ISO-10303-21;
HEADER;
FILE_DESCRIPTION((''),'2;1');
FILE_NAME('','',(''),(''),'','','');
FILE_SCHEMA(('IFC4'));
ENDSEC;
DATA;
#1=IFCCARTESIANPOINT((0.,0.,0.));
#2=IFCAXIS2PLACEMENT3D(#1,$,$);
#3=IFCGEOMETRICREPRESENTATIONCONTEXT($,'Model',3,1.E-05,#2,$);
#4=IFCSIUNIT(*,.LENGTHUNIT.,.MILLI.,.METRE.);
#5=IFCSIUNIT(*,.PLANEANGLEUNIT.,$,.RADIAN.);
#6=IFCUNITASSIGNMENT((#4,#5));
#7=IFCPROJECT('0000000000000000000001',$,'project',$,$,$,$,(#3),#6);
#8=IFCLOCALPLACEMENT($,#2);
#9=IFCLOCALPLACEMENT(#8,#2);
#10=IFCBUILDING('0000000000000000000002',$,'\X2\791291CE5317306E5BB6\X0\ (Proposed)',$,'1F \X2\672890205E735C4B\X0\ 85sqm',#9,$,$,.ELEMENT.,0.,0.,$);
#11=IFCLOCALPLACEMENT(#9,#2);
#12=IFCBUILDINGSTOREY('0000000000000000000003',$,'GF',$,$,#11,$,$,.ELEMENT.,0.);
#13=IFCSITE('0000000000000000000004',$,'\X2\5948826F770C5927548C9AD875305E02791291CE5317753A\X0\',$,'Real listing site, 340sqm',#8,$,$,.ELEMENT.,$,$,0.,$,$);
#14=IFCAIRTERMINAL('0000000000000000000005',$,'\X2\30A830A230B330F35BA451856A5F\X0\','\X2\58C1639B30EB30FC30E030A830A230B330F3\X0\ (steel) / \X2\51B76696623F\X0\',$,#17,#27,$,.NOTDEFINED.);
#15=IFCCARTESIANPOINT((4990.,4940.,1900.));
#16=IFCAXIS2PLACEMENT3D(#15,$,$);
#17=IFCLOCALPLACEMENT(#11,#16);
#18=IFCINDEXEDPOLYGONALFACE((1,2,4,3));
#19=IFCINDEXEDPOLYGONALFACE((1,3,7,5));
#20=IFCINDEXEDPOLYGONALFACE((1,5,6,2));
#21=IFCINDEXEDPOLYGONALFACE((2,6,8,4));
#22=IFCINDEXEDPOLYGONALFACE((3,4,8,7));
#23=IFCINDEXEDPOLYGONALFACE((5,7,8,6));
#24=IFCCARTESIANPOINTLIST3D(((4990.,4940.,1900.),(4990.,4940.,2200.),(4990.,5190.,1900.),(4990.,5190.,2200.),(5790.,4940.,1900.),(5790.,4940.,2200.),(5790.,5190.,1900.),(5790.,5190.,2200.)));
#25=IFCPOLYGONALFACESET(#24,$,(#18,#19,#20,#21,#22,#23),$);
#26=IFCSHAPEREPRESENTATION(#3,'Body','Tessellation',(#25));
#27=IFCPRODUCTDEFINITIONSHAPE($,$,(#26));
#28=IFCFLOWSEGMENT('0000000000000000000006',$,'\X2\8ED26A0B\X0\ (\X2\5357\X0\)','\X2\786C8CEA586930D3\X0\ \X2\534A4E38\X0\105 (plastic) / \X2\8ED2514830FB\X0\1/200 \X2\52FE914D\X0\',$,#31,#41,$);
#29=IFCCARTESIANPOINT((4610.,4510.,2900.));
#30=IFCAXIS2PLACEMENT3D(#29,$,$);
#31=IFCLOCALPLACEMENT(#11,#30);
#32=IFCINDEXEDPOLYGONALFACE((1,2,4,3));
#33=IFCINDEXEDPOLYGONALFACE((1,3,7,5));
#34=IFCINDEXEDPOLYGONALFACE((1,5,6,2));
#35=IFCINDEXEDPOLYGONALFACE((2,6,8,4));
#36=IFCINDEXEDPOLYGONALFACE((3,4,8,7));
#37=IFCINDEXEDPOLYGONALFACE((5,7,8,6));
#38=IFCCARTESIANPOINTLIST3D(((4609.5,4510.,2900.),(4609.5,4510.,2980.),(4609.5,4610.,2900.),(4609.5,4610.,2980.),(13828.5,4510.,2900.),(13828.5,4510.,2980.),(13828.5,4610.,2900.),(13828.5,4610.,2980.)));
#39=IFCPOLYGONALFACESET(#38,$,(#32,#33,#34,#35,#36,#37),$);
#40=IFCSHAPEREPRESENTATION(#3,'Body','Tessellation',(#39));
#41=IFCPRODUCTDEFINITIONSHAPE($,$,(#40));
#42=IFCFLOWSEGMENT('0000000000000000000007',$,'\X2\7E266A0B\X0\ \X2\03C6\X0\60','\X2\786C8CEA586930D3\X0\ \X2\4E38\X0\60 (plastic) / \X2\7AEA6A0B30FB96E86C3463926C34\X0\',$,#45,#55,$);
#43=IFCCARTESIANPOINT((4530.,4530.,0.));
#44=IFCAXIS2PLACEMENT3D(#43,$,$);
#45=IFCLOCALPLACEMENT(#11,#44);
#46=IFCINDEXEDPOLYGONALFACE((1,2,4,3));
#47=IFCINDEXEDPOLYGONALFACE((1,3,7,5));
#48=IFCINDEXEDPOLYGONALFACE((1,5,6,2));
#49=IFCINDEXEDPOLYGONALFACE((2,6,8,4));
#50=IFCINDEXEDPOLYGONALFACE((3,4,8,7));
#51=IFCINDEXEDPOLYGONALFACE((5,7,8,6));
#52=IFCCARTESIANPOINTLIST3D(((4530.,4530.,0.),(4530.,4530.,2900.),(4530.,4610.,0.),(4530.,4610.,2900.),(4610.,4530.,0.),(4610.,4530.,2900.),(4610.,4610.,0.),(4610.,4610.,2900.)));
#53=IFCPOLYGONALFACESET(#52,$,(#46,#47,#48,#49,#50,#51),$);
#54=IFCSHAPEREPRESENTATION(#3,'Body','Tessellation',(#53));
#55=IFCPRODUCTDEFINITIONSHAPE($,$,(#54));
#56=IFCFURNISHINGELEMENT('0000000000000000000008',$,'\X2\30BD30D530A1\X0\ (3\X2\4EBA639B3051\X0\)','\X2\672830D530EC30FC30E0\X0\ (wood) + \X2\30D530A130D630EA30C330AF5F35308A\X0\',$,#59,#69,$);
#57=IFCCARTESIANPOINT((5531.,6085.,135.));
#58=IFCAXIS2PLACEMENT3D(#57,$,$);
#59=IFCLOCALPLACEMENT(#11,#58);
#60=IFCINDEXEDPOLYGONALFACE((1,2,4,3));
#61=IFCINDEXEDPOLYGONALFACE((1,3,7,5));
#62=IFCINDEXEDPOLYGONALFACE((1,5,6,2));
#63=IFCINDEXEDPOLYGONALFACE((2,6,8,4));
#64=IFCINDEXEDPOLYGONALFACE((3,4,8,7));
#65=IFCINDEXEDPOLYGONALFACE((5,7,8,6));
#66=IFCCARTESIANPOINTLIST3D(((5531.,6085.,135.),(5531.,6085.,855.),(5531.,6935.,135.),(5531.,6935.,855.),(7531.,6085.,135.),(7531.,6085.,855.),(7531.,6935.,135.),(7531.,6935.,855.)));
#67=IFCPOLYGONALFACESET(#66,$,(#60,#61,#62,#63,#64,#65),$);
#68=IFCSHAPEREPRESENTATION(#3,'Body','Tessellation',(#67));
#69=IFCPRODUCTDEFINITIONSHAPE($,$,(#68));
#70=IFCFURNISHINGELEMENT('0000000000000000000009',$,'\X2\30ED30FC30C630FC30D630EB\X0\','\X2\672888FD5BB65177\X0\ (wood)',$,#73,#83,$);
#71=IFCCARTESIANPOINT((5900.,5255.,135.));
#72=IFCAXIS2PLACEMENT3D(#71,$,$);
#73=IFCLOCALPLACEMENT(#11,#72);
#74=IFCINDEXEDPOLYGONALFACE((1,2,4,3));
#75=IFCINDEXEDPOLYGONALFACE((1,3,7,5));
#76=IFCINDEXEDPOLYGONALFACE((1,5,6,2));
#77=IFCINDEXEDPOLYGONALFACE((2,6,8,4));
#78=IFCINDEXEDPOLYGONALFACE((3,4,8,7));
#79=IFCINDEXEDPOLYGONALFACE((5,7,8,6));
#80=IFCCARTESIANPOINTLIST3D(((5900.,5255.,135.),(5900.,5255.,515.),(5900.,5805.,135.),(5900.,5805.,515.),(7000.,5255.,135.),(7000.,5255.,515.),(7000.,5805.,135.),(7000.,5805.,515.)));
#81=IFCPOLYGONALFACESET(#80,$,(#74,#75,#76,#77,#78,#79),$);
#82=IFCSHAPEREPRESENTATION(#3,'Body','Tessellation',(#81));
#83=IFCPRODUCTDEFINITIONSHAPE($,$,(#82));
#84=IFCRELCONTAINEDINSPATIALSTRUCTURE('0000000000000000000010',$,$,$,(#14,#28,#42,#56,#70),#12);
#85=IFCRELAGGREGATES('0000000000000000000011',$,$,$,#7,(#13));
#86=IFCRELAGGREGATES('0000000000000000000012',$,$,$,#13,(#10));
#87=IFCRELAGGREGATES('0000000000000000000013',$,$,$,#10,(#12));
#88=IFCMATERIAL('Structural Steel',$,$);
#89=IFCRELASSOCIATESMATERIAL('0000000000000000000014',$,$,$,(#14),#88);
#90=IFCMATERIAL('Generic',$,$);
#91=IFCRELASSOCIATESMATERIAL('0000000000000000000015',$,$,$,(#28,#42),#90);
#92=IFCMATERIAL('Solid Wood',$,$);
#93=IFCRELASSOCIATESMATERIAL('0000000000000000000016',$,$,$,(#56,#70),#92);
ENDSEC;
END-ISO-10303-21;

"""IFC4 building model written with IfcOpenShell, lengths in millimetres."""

from ifc_helpers import new_model, si_unit, frame, frame_2d, origin, place, context, project, spatial, rectangle, extrude, material, element, save


model = new_model("IFC4")

# Units and contexts
model_context = context("Model", 3, precision=1e-05, world=origin())
ifc_project = project(units=[si_unit("LENGTHUNIT", "METRE", prefix="MILLI"), si_unit("PLANEANGLEUNIT", "RADIAN")], contexts=[model_context])

# Site, building, storey
site_placement = place(None, origin())
site = spatial("IfcSite", under=ifc_project, at=site_placement, Name="奈良県大和高田市礒野北町", ObjectType="Real listing site, 340sqm", CompositionType="ELEMENT", RefElevation=0.0)
building_placement = place(site_placement, origin())
building = spatial("IfcBuilding", under=site, at=building_placement, Name="礒野北の家 (Proposed)", ObjectType="1F 木造平屋 85sqm", CompositionType="ELEMENT", ElevationOfRefHeight=0.0, ElevationOfTerrain=0.0)
storey_placement = place(building_placement, origin())
storey = spatial("IfcBuildingStorey", under=building, at=storey_placement, Name="GF", CompositionType="ELEMENT", Elevation=0.0)

# Shared definitions
ifc_material_1 = material(Name="Solid Wood")

# Shared definitions
ifc_material_2 = material(Name="Structural Steel")

# Shared definitions
ifc_material_3 = material(Name="Generic")

# Air terminal
air_terminal_placement = place(storey_placement, frame((4990.0, 4940.0, 1900.0)))
element("IfcAirTerminal", 1, at=air_terminal_placement, inside=storey, material=ifc_material_2, Name="エアコン室内機", Description="壁掛ルームエアコン (steel) / 冷暖房", PredefinedType="NOTDEFINED", context=model_context, shape_type="SweptSolid", body=[
    extrude(rectangle(XDim=800.0, YDim=250.0, at=frame_2d((400.0, 125.0))), frame((4990.0, 4940.0, 1900.0)), (0.0, 0.0, 1.0), 300.0),
])

# Flow segments
flow_segment_1_placement = place(storey_placement, frame((4610.0, 4510.0, 2900.0)))
element("IfcFlowSegment", 2, at=flow_segment_1_placement, inside=storey, material=ifc_material_3, Name="軒樋 (南)", Description="硬質塩ビ 半丸105 (plastic) / 軒先・1/200 勾配", context=model_context, shape_type="SweptSolid", body=[
    extrude(rectangle(XDim=9219.0, YDim=100.0, at=frame_2d((4609.0, 50.0))), frame((4610.0, 4510.0, 2900.0)), (0.0, 0.0, 1.0), 80.0),
])
flow_segment_2_placement = place(storey_placement, frame((4530.0, 4530.0, 0.0)))
element("IfcFlowSegment", 3, at=flow_segment_2_placement, inside=storey, material=ifc_material_3, Name="縦樋 φ60", Description="硬質塩ビ 丸60 (plastic) / 竪樋・雨水排水", context=model_context, shape_type="SweptSolid", body=[
    extrude(rectangle(XDim=80.0, YDim=80.0, at=frame_2d((40.0, 40.0))), frame((4530.0, 4530.0, 0.0)), (0.0, 0.0, 1.0), 2900.0),
])

# Furnishing elements
furnishing_1_placement = place(storey_placement, frame((5531.0, 6085.0, 135.0)))
element("IfcFurnishingElement", 4, at=furnishing_1_placement, inside=storey, material=ifc_material_1, Name="ソファ (3人掛け)", Description="木フレーム (wood) + ファブリック張り", context=model_context, shape_type="SweptSolid", body=[
    extrude(rectangle(XDim=2000.0, YDim=850.0, at=frame_2d((1000.0, 425.0))), frame((5531.0, 6085.0, 135.0)), (0.0, 0.0, 1.0), 720.0),
])
furnishing_2_placement = place(storey_placement, frame((5900.0, 5255.0, 135.0)))
element("IfcFurnishingElement", 5, at=furnishing_2_placement, inside=storey, material=ifc_material_1, Name="ローテーブル", Description="木製家具 (wood)", context=model_context, shape_type="SweptSolid", body=[
    extrude(rectangle(XDim=1100.0, YDim=550.0, at=frame_2d((550.0, 275.0))), frame((5900.0, 5255.0, 135.0)), (0.0, 0.0, 1.0), 380.0),
])

save(model, "model.ifc")
